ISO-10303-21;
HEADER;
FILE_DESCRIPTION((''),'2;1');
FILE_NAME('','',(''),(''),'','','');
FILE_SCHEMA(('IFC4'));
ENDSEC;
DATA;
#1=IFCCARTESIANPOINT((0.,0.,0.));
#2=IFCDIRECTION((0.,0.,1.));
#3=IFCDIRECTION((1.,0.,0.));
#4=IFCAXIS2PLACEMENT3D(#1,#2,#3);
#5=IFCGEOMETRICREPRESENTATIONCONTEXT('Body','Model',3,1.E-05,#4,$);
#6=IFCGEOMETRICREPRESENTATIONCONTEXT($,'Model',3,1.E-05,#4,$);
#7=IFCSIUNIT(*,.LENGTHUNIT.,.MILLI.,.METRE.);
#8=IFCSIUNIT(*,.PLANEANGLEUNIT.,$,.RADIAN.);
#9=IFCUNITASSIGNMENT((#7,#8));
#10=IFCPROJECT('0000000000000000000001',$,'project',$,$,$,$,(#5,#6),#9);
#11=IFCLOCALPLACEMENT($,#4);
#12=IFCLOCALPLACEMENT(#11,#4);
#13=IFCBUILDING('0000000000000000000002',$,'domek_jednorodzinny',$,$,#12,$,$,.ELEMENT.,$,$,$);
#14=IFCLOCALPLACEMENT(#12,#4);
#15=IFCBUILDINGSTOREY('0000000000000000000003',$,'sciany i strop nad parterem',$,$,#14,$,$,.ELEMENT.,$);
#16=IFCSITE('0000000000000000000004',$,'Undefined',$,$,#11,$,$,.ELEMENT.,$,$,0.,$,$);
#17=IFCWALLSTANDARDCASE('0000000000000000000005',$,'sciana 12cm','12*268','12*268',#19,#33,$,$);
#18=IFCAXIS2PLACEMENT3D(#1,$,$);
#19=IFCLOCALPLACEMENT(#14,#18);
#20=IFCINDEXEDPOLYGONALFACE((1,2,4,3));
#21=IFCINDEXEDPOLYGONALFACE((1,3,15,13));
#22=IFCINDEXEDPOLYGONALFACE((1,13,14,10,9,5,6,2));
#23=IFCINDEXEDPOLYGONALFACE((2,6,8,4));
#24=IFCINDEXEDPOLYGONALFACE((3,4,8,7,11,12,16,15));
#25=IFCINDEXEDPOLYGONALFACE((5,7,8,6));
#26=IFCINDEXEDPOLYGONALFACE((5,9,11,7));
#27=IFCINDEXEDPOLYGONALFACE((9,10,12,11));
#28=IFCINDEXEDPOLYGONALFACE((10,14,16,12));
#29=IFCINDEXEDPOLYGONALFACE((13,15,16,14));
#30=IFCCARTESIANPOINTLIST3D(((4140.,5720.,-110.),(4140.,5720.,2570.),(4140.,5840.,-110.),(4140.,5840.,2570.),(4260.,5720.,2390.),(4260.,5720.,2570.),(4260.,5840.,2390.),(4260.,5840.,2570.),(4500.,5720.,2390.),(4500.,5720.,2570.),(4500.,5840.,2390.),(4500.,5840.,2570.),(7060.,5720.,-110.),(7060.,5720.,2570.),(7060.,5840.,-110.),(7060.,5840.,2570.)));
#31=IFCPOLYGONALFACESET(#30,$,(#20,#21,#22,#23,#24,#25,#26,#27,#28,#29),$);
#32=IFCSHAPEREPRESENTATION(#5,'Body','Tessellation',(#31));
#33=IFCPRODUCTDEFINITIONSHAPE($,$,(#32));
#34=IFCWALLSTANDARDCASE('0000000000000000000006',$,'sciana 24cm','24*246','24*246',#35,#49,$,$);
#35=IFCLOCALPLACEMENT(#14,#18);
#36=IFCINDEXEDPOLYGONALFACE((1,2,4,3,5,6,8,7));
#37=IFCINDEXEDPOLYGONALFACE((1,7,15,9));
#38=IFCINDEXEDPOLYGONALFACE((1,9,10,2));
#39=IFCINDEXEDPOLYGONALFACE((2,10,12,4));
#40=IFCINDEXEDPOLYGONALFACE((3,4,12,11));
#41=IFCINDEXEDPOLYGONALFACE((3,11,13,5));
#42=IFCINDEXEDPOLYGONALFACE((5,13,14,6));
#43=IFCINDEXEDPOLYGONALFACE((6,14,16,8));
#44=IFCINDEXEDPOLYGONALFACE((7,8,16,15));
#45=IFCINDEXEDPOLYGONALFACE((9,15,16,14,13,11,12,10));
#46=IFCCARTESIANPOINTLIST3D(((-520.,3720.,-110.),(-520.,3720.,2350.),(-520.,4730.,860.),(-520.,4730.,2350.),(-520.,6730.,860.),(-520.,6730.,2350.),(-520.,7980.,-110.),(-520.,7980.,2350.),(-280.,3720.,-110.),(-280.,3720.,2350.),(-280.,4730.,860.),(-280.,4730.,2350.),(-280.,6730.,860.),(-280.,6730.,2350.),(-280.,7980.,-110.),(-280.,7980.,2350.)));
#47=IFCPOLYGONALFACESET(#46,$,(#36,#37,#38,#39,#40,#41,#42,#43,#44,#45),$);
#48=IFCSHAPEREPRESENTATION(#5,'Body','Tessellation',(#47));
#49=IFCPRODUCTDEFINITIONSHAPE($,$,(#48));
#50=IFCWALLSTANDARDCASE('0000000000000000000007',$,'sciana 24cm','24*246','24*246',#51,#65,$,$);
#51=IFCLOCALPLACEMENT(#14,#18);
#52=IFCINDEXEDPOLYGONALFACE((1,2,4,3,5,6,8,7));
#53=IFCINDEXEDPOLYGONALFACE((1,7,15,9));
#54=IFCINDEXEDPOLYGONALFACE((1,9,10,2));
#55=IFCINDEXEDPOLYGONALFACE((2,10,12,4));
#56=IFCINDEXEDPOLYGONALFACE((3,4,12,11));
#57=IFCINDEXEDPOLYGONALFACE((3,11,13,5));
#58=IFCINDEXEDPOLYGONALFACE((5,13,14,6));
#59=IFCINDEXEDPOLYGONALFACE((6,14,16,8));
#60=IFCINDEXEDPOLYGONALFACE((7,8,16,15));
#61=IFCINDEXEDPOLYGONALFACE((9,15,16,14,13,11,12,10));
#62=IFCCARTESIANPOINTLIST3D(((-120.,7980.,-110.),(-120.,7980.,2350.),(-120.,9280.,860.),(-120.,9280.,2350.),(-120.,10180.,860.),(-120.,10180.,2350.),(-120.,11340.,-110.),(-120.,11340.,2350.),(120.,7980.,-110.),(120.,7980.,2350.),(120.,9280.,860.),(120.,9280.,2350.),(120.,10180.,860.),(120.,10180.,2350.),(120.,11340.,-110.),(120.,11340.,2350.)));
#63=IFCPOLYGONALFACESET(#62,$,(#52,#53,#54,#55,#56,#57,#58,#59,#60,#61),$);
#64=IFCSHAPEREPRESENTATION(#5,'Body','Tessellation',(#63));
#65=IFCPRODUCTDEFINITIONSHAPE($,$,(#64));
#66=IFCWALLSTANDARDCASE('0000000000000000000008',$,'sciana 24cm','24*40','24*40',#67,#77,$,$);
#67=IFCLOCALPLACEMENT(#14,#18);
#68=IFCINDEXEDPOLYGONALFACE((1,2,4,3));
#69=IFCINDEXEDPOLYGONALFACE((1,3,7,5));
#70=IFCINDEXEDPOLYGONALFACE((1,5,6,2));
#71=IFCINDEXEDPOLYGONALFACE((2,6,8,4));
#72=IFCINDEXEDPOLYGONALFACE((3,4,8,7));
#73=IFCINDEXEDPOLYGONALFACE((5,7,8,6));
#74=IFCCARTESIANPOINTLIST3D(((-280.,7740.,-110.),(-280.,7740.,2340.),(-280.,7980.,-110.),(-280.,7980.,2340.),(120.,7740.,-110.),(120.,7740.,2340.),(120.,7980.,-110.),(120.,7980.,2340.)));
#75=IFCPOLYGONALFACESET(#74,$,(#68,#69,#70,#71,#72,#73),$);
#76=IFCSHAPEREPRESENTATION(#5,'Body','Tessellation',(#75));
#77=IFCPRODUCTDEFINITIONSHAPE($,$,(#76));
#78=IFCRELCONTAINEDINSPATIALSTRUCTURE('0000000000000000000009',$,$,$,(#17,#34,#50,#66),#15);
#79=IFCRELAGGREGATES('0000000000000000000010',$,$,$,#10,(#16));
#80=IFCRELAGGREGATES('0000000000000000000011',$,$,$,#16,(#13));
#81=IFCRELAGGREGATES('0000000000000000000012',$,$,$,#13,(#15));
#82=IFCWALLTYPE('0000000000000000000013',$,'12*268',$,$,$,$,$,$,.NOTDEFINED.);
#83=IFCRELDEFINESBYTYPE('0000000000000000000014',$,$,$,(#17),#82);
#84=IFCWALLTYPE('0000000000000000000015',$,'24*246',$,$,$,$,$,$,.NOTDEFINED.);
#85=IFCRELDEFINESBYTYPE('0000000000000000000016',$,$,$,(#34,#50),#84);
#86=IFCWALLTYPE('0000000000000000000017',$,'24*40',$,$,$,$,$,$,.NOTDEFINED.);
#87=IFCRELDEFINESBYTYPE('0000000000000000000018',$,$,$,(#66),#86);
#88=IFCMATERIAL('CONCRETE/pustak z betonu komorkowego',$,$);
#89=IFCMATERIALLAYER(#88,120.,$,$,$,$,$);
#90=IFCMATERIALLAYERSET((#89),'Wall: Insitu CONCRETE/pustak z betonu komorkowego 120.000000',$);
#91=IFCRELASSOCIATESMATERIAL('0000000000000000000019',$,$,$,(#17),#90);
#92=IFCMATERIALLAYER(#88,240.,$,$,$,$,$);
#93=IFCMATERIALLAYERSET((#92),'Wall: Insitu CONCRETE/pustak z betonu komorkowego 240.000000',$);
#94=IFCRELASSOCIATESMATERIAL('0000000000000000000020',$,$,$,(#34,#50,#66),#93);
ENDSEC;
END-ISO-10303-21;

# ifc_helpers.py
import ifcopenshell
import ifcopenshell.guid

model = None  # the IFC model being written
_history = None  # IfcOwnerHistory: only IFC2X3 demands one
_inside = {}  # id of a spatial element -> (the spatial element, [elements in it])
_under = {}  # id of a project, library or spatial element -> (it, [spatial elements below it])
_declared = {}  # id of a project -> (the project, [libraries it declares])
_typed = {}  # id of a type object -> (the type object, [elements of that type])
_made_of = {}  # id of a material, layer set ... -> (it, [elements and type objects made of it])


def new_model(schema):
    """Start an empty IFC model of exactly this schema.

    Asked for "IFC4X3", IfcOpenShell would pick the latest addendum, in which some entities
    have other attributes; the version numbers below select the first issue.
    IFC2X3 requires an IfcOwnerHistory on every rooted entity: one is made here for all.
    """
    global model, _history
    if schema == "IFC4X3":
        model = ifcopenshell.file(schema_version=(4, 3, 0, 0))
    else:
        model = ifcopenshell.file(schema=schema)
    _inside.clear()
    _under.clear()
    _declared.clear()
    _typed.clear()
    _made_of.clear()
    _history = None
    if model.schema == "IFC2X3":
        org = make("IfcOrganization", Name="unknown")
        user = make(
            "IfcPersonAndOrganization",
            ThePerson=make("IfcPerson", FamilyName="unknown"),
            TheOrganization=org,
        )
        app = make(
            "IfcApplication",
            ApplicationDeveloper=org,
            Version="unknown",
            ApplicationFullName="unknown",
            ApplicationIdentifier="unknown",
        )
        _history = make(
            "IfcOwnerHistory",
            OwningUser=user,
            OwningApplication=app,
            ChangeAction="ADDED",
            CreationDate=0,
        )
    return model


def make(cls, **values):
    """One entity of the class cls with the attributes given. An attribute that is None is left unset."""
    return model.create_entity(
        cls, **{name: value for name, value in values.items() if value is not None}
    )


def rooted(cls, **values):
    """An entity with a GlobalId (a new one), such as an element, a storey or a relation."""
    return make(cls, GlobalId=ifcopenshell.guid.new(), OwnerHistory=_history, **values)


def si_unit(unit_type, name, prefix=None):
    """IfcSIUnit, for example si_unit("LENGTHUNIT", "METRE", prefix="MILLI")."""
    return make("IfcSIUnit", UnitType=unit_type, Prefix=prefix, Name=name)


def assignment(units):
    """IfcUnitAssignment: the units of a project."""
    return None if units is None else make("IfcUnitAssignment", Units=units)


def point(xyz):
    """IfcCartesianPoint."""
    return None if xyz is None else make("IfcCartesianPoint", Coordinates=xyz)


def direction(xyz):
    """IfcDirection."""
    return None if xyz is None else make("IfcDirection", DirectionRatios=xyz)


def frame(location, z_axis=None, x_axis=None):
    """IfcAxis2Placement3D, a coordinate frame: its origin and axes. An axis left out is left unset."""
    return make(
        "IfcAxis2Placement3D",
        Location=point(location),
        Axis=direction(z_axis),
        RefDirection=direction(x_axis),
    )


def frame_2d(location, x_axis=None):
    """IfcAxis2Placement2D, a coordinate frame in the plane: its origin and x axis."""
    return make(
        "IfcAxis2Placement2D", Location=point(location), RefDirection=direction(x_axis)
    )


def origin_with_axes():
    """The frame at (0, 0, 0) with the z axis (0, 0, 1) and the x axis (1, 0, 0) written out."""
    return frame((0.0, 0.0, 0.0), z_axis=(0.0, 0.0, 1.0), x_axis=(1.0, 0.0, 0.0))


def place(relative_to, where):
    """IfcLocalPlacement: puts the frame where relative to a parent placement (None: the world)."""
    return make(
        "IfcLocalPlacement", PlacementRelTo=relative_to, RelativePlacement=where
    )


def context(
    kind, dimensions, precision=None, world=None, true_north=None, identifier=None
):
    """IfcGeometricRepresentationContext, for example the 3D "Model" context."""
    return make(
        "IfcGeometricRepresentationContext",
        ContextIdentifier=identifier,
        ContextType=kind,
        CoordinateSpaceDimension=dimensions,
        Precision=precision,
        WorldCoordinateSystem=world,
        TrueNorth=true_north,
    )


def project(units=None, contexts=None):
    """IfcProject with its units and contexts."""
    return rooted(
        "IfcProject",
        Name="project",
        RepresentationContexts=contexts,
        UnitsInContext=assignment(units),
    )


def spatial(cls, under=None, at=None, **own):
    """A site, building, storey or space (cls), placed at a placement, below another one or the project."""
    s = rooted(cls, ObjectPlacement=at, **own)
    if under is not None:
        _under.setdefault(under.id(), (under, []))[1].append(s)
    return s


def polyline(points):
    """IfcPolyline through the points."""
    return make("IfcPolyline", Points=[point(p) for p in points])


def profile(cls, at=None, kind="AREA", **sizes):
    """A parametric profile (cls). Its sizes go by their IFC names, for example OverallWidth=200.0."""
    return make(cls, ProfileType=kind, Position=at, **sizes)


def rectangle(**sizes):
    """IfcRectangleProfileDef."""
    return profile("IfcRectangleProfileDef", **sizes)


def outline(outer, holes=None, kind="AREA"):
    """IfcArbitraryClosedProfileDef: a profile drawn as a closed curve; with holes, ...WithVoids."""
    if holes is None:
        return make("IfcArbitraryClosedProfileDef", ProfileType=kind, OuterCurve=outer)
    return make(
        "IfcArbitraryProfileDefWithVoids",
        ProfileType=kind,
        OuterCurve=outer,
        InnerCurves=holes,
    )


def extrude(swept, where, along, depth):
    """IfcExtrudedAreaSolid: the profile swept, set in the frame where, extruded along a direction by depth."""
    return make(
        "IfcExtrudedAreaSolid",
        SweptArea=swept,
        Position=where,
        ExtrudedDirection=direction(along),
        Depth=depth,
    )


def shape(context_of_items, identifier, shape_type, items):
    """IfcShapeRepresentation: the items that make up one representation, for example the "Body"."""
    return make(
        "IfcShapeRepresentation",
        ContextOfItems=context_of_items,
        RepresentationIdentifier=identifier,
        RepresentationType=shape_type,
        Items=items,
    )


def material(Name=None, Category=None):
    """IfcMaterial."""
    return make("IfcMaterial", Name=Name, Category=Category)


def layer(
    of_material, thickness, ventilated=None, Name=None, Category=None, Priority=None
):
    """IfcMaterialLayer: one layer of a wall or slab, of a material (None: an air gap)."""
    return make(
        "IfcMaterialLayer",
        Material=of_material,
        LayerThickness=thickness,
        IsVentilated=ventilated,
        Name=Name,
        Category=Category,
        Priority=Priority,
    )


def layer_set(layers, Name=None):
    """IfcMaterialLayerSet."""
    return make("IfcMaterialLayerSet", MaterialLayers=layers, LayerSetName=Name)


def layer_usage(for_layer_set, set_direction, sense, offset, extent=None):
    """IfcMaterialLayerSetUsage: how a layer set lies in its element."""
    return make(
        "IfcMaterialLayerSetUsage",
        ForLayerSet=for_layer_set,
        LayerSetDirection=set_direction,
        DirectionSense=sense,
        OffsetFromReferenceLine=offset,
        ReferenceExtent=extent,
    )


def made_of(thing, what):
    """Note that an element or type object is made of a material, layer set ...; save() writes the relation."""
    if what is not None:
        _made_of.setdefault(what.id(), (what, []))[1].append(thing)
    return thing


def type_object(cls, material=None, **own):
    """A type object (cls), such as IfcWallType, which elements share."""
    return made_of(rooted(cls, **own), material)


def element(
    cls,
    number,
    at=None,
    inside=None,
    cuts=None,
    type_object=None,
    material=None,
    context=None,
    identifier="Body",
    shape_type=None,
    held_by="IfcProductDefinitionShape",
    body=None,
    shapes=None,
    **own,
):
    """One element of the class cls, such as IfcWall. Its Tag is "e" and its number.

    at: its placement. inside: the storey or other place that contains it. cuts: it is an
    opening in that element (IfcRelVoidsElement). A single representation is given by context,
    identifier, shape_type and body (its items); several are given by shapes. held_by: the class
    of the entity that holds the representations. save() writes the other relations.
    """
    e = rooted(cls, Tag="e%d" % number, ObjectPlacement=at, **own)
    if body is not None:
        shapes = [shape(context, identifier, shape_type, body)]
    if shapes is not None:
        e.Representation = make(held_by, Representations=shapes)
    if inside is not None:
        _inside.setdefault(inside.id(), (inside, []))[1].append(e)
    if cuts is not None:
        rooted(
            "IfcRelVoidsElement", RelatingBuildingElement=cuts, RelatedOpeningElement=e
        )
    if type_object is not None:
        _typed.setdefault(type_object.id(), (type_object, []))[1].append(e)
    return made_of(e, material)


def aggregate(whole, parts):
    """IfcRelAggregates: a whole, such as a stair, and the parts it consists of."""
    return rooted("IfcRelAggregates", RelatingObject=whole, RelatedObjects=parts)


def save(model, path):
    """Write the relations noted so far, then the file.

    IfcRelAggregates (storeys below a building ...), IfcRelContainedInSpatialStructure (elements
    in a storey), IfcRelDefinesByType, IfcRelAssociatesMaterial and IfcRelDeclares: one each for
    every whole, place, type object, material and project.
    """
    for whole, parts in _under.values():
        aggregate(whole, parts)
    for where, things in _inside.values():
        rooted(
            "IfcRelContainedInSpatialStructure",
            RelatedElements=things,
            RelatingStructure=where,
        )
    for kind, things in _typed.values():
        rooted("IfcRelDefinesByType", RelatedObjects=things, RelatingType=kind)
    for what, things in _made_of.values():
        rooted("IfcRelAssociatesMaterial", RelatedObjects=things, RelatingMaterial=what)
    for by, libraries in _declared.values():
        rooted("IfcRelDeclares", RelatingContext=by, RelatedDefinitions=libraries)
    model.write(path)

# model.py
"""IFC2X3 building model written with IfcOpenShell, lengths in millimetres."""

from ifc_helpers import new_model, si_unit, frame, frame_2d, origin_with_axes, place, context, project, spatial, polyline, rectangle, outline, extrude, material, layer, layer_set, layer_usage, type_object, element, save


model = new_model("IFC2X3")

# Units and contexts
model_context_1 = context("Model", 3, precision=1e-05, world=origin_with_axes(), identifier="Body")
model_context_2 = context("Model", 3, precision=1e-05, world=origin_with_axes())
ifc_project = project(units=[si_unit("LENGTHUNIT", "METRE", prefix="MILLI"), si_unit("PLANEANGLEUNIT", "RADIAN")], contexts=[model_context_1, model_context_2])

# Site, building, storey
site_placement = place(None, origin_with_axes())
site = spatial("IfcSite", under=ifc_project, at=site_placement, Name="Undefined", CompositionType="ELEMENT", RefElevation=0.0)
building_placement = place(site_placement, origin_with_axes())
building = spatial("IfcBuilding", under=site, at=building_placement, Name="domek_jednorodzinny", CompositionType="ELEMENT")
storey_placement = place(building_placement, origin_with_axes())
storey = spatial("IfcBuildingStorey", under=building, at=storey_placement, Name="sciany i strop nad parterem", CompositionType="ELEMENT")

# Shared definitions
ifc_material_1 = material(Name="CONCRETE/pustak z betonu komorkowego")

# Shared definitions
ifc_layer_1 = layer(ifc_material_1, 120.0)
ifc_layer_set_1 = layer_set([ifc_layer_1], Name="Wall: Insitu CONCRETE/pustak z betonu komorkowego 120.000000")

# Walls, openings
ifc_layer_usage_1 = layer_usage(ifc_layer_set_1, "AXIS2", "POSITIVE", -60.0)
wall_type_1 = type_object("IfcWallType", Name="12*268", PredefinedType="NOTDEFINED")
wall_1_placement = place(storey_placement, frame((4140.0, 5780.0, -110.0), z_axis=(0.0, 0.0, 1.0), x_axis=(1.0, 0.0, 0.0)))
wall_1 = element("IfcWallStandardCase", 1, at=wall_1_placement, inside=storey, type_object=wall_type_1, material=ifc_layer_usage_1, Name="sciana 12cm", Description="12*268", ObjectType="12*268", context=model_context_1, shape_type="SweptSolid", body=[
    extrude(rectangle(XDim=2920.0, YDim=120.0, at=frame_2d((0.0, 1460.0), x_axis=(0.0, -1.0))), frame((0.0, 0.0, 0.0), z_axis=(0.0, 0.0, 1.0), x_axis=(0.0, -1.0, 0.0)), (0.0, 0.0, 1.0), 2680.0),
])
opening_1_placement = place(storey_placement, frame((4140.0, 5780.0, -110.0), z_axis=(0.0, 0.0, 1.0), x_axis=(1.0, 0.0, 0.0)))
element("IfcOpeningElement", 2, at=opening_1_placement, cuts=wall_1, ObjectType="Recess", context=model_context_1, shape_type="SweptSolid", body=[
    extrude(outline(polyline([(0.0, 0.0), (180.0, 0.0), (180.0, 240.0), (0.0, 240.0), (0.0, 0.0)])), frame((360.0, -63.0, 2680.0), z_axis=(0.0, 1.0, 0.0), x_axis=(0.000001, 0.000001, -1.0)), (0.0, 0.0, 1.0), 126.0),
])
ifc_layer_2 = layer(ifc_material_1, 240.0)
ifc_layer_set_2 = layer_set([ifc_layer_2], Name="Wall: Insitu CONCRETE/pustak z betonu komorkowego 240.000000")
ifc_layer_usage_2 = layer_usage(ifc_layer_set_2, "AXIS2", "POSITIVE", -120.0)
wall_type_2 = type_object("IfcWallType", Name="24*246", PredefinedType="NOTDEFINED")
wall_2_placement = place(storey_placement, frame((-400.0, 3720.0, -110.0), z_axis=(0.0, 0.0, 1.0), x_axis=(0.0, 1.0, 0.0)))
wall_2 = element("IfcWallStandardCase", 3, at=wall_2_placement, inside=storey, type_object=wall_type_2, material=ifc_layer_usage_2, Name="sciana 24cm", Description="24*246", ObjectType="24*246", context=model_context_1, shape_type="SweptSolid", body=[
    extrude(rectangle(XDim=4260.0, YDim=240.0, at=frame_2d((0.0, 2130.0), x_axis=(0.0, -1.0))), frame((0.0, 0.0, 0.0), z_axis=(0.0, 0.0, 1.0), x_axis=(0.0, -1.0, 0.0)), (0.0, 0.0, 1.0), 2460.0),
])
opening_2_placement = place(storey_placement, frame((-400.0, 3720.0, -110.0), z_axis=(0.0, 0.0, 1.0), x_axis=(0.0, 1.0, 0.0)))
element("IfcOpeningElement", 4, at=opening_2_placement, cuts=wall_2, ObjectType="Recess", context=model_context_1, shape_type="SweptSolid", body=[
    extrude(outline(polyline([(0.0, 0.0), (350.0, 0.0), (350.0, 2000.0), (0.0, 2000.0), (0.0, 0.0)])), frame((3010.0, -180.0, 970.0), z_axis=(0.0, 0.0, 1.0), x_axis=(0.0, 1.0, 0.0)), (0.0, 0.0, 1.0), 1500.0),
])
ifc_layer_usage_3 = layer_usage(ifc_layer_set_2, "AXIS2", "POSITIVE", -120.0)
wall_3_placement = place(storey_placement, frame((0.0, 7980.0, -110.0), z_axis=(0.0, 0.0, 1.0), x_axis=(0.0, 1.0, 0.0)))
wall_3 = element("IfcWallStandardCase", 5, at=wall_3_placement, inside=storey, type_object=wall_type_2, material=ifc_layer_usage_3, Name="sciana 24cm", Description="24*246", ObjectType="24*246", context=model_context_1, shape_type="SweptSolid", body=[
    extrude(rectangle(XDim=3360.0, YDim=240.0, at=frame_2d((0.0, 1680.0), x_axis=(0.0, -1.0))), frame((0.0, 0.0, 0.0), z_axis=(0.0, 0.0, 1.0), x_axis=(0.0, -1.0, 0.0)), (0.0, 0.0, 1.0), 2460.0),
])
opening_3_placement = place(storey_placement, frame((0.0, 7980.0, -110.0), z_axis=(0.0, 0.0, 1.0), x_axis=(0.0, 1.0, 0.0)))
element("IfcOpeningElement", 6, at=opening_3_placement, cuts=wall_3, ObjectType="Recess", context=model_context_1, shape_type="SweptSolid", body=[
    extrude(outline(polyline([(0.0, 0.0), (360.0, 0.0), (360.0, 900.0), (0.0, 900.0), (0.0, 0.0)])), frame((2200.0, -180.0, 970.0), z_axis=(0.0, 0.0, 1.0), x_axis=(0.0, 1.0, 0.0)), (0.0, 0.0, 1.0), 1500.0),
])

# Wall
ifc_layer_usage_4 = layer_usage(ifc_layer_set_2, "AXIS2", "POSITIVE", -120.0)
wall_type_3 = type_object("IfcWallType", Name="24*40", PredefinedType="NOTDEFINED")
wall_4_placement = place(storey_placement, frame((-280.0, 7860.0, -110.0), z_axis=(0.0, 0.0, 1.0), x_axis=(1.0, -0.000054, 0.0)))
element("IfcWallStandardCase", 7, at=wall_4_placement, inside=storey, type_object=wall_type_3, material=ifc_layer_usage_4, Name="sciana 24cm", Description="24*40", ObjectType="24*40", context=model_context_1, shape_type="SweptSolid", body=[
    extrude(rectangle(XDim=400.0, YDim=240.0, at=frame_2d((0.0, 200.0), x_axis=(0.0, -1.0))), frame((0.0, 0.0, 0.0), z_axis=(0.0, 0.0, 1.0), x_axis=(0.0, -1.0, 0.0)), (0.0, 0.0, 1.0), 2450.0),
])

save(model, "model.ifc")
